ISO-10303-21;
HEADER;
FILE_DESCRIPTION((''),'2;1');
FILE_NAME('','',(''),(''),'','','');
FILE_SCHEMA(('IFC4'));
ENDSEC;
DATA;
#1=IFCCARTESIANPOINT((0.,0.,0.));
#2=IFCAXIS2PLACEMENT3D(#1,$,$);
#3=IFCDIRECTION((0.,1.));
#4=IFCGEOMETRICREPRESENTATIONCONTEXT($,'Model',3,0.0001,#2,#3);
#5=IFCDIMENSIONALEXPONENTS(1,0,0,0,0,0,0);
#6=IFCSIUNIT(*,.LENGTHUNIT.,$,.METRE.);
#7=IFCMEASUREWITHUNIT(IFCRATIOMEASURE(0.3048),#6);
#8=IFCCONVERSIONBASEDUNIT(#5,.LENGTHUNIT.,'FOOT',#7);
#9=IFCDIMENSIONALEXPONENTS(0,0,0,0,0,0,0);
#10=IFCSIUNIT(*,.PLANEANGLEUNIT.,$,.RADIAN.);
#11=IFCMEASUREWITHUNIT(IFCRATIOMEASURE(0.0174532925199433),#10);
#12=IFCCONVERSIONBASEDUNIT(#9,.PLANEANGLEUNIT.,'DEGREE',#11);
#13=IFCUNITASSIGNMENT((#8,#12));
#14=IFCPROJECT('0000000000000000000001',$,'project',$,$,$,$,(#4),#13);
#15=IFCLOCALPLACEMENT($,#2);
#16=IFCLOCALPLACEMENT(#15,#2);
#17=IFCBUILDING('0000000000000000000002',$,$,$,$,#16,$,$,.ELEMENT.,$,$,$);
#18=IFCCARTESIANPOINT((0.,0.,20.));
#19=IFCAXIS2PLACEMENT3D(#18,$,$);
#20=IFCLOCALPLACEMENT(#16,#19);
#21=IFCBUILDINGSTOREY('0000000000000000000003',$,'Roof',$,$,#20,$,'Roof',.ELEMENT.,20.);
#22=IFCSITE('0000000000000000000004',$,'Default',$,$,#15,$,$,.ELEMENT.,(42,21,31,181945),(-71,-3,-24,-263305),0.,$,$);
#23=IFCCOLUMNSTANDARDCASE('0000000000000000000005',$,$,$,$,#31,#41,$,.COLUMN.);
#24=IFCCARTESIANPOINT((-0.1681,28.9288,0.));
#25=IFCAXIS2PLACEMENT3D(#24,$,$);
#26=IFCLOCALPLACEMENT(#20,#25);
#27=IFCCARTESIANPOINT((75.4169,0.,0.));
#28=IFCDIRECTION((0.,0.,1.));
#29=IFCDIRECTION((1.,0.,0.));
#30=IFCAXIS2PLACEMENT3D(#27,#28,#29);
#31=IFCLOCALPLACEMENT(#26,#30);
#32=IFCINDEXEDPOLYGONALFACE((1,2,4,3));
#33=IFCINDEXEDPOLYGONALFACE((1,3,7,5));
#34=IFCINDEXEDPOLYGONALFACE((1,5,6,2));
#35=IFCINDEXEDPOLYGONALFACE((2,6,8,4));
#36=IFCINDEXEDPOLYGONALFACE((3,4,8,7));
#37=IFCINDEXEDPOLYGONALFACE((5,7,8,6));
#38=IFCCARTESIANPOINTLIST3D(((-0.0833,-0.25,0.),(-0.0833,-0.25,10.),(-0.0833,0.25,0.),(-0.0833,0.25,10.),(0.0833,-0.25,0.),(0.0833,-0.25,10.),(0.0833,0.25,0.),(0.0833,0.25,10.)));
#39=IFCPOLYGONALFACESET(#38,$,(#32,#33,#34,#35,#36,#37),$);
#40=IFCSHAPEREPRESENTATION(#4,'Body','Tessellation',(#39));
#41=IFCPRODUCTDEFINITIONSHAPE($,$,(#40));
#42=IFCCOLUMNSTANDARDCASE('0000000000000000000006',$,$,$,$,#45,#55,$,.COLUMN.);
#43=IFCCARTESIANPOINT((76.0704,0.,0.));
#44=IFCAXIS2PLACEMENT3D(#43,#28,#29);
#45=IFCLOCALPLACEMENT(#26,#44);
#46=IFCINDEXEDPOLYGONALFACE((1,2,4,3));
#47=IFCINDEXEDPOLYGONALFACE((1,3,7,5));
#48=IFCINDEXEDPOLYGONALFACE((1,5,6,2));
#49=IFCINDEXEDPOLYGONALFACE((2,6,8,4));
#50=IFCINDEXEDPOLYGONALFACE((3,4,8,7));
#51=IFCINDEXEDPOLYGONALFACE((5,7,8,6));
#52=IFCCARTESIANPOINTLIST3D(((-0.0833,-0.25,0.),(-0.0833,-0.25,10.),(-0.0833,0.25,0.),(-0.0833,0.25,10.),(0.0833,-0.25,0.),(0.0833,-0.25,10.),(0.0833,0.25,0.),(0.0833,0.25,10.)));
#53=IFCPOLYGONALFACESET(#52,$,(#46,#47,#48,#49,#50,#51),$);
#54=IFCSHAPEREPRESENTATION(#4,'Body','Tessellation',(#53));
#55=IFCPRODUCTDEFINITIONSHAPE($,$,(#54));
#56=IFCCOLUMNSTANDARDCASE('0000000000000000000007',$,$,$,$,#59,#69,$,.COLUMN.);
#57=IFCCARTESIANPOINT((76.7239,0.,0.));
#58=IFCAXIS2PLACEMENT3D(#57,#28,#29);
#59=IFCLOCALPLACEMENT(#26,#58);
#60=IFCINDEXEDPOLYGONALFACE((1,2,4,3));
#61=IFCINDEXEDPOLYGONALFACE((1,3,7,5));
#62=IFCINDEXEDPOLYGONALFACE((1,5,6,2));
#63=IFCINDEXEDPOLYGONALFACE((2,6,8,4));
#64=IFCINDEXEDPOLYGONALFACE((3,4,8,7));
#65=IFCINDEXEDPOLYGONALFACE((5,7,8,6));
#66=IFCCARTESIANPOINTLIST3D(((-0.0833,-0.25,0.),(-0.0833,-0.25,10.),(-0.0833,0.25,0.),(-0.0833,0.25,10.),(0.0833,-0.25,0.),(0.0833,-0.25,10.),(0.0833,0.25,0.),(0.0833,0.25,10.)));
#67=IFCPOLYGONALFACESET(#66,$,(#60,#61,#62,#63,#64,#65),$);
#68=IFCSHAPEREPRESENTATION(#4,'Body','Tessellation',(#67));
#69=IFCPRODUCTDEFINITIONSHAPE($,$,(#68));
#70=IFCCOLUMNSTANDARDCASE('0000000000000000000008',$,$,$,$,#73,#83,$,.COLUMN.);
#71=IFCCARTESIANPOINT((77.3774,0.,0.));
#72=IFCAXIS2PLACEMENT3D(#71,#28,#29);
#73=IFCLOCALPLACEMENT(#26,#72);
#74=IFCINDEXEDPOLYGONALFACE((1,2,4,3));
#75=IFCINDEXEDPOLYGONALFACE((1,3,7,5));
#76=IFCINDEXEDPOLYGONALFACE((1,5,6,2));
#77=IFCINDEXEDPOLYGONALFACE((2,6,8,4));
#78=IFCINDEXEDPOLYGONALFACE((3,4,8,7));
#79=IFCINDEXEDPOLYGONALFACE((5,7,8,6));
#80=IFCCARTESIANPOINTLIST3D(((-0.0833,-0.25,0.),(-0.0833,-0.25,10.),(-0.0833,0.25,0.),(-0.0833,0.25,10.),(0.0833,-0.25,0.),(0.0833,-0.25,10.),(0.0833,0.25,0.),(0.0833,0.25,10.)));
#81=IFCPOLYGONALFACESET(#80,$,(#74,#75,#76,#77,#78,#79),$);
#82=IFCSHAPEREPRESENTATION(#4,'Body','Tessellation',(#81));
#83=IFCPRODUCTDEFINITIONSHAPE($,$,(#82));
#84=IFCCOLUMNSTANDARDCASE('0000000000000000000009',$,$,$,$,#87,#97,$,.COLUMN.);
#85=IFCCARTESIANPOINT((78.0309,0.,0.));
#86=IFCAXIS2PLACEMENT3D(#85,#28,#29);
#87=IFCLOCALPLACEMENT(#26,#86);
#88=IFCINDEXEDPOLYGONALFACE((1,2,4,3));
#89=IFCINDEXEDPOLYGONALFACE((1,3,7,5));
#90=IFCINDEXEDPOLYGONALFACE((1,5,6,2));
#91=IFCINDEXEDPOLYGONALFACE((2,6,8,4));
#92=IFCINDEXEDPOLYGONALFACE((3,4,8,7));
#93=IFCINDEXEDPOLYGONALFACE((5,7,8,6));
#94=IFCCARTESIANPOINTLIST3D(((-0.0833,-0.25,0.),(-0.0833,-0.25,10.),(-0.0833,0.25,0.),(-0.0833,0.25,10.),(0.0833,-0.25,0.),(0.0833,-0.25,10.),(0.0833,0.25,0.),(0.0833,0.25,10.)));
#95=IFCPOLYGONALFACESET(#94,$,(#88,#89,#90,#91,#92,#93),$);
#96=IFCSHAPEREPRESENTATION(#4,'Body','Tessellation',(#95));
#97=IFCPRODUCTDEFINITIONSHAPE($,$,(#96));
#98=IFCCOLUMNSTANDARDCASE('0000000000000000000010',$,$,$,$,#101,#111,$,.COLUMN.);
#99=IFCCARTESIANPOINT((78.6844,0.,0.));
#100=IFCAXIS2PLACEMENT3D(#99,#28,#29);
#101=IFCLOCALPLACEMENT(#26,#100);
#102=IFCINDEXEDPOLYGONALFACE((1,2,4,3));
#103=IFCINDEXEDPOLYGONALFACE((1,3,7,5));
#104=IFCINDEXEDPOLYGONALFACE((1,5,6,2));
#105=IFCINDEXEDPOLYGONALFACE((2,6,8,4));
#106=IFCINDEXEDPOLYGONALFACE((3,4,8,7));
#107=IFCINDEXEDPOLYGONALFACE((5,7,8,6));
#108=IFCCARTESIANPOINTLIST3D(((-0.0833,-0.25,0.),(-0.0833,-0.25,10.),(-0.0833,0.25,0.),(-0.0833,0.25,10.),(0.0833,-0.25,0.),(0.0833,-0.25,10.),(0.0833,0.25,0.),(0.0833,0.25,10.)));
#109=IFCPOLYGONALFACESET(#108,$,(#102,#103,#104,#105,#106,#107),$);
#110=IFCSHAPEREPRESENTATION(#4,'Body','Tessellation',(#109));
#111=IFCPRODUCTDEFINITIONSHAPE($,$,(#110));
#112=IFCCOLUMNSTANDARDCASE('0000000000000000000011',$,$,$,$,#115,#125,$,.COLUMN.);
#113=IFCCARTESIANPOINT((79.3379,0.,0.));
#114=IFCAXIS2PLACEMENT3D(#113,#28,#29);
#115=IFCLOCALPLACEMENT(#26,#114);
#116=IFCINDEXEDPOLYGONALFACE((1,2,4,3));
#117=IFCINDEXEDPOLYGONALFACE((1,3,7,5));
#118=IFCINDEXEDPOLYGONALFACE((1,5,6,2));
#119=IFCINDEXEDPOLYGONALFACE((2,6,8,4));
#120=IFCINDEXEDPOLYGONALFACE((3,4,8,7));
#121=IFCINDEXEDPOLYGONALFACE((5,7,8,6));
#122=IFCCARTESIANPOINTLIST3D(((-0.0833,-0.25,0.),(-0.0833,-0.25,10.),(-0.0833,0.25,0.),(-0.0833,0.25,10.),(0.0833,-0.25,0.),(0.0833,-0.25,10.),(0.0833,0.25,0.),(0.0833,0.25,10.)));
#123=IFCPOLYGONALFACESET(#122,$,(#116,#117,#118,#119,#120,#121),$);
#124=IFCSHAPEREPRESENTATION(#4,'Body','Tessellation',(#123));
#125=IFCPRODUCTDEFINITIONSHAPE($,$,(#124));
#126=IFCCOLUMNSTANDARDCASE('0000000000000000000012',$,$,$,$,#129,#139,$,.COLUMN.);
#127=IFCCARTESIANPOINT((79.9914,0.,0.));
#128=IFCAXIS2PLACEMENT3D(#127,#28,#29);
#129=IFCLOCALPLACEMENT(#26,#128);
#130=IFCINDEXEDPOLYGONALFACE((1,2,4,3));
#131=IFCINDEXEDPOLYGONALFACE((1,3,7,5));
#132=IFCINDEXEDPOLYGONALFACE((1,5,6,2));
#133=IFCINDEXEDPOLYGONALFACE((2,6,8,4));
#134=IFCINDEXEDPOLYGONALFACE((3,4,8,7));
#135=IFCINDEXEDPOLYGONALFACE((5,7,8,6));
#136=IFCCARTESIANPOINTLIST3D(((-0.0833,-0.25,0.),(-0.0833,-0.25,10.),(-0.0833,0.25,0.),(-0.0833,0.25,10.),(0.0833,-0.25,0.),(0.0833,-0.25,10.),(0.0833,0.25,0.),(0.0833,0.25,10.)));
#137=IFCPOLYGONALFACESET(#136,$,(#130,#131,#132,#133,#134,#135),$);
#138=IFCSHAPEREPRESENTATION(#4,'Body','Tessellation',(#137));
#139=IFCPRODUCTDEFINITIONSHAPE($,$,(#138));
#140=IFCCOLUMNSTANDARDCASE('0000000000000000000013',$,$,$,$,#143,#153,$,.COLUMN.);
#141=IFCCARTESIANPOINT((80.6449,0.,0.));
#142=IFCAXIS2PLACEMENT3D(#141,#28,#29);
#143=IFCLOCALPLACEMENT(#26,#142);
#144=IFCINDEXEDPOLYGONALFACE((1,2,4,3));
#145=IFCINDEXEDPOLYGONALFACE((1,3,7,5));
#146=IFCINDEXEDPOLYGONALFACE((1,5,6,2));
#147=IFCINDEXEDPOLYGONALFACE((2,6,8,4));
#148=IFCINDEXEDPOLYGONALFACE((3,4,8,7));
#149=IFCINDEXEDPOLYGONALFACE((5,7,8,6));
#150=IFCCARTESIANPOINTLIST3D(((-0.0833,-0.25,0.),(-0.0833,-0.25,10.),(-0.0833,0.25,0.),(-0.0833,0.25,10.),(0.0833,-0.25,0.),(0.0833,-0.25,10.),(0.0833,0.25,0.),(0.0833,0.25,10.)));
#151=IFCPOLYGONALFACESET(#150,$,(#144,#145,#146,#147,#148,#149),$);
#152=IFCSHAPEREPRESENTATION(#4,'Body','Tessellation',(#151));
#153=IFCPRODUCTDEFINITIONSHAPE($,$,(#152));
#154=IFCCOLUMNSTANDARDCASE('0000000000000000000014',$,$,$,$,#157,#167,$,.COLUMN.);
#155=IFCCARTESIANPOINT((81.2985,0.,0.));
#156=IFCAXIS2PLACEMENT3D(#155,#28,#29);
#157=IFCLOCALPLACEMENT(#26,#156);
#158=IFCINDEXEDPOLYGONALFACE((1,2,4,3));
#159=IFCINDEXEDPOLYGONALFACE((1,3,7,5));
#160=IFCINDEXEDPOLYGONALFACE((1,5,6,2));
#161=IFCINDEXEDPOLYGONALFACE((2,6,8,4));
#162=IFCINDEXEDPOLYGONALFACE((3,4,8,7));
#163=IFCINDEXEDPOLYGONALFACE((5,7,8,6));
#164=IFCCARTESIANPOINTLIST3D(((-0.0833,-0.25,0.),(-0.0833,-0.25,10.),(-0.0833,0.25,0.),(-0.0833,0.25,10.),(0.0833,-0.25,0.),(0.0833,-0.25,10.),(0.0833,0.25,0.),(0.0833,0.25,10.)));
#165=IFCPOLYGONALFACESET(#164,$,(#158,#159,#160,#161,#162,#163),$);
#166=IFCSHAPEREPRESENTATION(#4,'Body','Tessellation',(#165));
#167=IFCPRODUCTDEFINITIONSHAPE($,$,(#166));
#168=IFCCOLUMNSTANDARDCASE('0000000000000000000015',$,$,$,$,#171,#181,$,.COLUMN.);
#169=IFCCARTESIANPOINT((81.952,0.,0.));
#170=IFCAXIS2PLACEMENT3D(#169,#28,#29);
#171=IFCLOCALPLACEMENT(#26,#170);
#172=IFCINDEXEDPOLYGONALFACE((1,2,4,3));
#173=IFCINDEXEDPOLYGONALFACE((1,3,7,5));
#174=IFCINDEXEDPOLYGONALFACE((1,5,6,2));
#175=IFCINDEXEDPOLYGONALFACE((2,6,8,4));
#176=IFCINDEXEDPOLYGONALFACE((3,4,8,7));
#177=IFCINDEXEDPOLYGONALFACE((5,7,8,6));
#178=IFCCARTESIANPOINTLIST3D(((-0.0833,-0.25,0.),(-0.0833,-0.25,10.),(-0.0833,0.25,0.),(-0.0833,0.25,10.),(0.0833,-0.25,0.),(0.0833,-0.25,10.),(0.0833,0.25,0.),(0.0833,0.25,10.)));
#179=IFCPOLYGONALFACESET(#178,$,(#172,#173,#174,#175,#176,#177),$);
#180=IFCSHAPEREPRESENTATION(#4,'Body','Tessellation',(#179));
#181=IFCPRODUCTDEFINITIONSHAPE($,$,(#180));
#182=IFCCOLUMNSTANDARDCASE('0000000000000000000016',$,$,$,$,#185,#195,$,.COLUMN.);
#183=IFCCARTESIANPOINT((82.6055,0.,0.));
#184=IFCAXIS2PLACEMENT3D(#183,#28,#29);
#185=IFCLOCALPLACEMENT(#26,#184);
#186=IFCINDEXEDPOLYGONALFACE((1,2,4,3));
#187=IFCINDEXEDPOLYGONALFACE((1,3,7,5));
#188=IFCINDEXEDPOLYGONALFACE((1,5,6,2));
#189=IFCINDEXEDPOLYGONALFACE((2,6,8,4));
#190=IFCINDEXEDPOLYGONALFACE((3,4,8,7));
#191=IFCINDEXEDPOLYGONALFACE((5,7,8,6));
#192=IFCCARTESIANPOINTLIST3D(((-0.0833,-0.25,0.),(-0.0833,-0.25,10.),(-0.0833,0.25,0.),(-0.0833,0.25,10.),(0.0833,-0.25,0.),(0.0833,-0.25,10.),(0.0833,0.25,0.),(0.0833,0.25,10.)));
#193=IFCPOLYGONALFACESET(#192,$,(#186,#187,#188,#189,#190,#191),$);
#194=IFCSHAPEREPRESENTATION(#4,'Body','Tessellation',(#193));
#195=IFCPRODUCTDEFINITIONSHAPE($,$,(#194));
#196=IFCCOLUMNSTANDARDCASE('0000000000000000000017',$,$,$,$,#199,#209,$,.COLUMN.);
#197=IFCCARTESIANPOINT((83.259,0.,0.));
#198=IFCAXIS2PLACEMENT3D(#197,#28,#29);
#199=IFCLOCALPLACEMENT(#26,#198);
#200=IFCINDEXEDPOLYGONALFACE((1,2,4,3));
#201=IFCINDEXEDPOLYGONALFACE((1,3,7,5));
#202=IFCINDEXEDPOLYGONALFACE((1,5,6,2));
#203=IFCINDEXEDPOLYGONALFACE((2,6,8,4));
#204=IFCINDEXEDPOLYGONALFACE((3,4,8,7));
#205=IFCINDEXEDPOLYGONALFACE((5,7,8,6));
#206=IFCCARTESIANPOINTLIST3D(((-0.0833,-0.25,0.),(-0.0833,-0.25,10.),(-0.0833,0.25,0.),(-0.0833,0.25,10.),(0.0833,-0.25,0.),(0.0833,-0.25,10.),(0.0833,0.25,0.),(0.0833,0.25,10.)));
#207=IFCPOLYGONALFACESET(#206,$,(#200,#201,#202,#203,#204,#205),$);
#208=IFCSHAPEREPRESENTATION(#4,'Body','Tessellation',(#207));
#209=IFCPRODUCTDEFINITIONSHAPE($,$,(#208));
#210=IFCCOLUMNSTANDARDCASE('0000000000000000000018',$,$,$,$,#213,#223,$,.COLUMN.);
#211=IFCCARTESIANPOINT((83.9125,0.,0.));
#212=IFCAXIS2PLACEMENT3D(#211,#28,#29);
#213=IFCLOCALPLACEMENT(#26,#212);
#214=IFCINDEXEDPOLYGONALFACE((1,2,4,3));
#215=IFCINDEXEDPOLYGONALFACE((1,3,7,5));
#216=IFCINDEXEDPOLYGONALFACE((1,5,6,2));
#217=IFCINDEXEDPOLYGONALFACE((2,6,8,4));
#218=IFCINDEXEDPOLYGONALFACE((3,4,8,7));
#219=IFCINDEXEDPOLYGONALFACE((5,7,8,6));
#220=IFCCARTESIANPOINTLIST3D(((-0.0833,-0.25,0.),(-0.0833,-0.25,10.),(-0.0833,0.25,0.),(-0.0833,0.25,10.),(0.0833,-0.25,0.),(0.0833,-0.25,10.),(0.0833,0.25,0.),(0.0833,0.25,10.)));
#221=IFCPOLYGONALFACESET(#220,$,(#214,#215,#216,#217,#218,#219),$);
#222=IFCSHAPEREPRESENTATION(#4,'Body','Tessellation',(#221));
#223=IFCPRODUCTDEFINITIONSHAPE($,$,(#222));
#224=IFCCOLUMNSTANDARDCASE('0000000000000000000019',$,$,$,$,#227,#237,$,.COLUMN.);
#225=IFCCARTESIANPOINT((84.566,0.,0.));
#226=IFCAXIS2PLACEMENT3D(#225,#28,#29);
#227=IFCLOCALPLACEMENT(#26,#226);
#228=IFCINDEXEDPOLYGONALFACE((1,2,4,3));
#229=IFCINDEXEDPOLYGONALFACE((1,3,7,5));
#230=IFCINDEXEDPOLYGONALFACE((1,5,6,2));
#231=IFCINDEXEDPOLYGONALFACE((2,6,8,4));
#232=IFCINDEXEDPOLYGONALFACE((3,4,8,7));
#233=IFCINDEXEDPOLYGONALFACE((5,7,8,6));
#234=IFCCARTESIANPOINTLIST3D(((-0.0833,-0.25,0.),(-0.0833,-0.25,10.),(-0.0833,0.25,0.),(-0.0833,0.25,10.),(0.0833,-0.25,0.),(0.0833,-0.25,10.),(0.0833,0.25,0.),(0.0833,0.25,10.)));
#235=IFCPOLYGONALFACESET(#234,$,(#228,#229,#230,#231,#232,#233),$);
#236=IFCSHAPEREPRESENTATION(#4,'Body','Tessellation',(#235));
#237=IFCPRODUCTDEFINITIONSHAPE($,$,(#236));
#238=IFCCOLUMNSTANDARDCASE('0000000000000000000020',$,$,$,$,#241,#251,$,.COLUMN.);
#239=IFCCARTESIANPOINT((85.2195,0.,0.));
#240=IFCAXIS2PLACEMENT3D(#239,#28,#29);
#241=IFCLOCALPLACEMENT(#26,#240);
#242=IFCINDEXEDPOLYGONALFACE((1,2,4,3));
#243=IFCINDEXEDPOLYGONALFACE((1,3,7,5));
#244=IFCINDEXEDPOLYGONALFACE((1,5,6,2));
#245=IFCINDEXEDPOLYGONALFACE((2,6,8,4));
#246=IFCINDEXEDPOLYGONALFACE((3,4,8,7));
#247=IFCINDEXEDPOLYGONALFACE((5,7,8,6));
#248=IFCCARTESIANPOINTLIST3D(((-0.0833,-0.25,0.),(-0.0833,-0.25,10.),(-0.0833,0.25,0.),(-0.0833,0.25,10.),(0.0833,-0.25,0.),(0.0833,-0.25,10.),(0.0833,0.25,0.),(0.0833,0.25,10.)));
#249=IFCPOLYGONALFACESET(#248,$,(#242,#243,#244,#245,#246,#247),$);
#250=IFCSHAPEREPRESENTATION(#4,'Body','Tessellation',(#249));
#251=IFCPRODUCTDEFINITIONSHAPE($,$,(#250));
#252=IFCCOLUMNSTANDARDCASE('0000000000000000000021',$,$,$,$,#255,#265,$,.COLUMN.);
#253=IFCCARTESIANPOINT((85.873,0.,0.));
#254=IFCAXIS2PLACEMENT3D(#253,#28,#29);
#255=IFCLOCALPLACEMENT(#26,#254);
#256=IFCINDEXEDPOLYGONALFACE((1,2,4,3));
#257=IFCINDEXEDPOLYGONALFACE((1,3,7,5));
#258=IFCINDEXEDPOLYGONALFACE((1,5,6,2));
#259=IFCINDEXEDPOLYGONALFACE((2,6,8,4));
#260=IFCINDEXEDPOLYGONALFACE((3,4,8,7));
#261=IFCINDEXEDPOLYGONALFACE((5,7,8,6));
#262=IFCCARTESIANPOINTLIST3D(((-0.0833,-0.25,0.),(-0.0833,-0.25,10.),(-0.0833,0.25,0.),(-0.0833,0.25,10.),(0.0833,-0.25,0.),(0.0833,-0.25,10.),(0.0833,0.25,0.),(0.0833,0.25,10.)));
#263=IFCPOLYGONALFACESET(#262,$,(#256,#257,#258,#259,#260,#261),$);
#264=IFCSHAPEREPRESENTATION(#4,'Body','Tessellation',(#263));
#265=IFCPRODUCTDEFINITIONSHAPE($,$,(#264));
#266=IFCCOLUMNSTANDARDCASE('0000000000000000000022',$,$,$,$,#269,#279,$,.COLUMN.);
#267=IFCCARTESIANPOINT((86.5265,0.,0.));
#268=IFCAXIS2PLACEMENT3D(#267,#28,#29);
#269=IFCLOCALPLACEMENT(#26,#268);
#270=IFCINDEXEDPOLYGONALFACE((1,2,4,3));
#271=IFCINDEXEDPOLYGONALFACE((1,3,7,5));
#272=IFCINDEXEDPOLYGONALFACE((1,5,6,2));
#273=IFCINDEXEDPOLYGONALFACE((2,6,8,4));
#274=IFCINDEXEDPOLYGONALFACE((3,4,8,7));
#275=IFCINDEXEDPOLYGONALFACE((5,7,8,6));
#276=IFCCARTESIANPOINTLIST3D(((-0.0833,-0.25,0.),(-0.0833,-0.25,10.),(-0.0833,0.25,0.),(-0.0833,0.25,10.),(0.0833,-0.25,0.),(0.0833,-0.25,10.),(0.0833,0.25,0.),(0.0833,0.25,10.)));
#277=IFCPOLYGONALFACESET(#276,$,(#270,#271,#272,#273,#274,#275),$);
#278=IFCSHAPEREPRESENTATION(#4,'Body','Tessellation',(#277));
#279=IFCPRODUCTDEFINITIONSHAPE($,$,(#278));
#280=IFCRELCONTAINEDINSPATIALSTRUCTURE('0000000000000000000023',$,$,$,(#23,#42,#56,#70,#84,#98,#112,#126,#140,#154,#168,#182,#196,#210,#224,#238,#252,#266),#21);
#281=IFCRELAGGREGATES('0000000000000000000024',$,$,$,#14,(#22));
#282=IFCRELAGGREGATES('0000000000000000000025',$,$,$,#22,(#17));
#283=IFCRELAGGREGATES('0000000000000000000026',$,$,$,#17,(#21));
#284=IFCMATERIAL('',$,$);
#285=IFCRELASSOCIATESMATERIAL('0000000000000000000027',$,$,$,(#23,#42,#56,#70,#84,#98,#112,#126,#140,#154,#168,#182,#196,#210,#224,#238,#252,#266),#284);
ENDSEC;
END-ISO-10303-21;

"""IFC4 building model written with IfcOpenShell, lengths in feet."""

from ifc_helpers import new_model, entity, si_unit, converted_unit, direction, frame, origin, place, context, project, spatial, rectangle, extrude, material, element, save


model = new_model("IFC4")

# Units and contexts
model_context = context("Model", 3, precision=0.0001, world=origin(), true_north=direction((0.0, 1.0)))
ifc_project = project(units=[converted_unit("LENGTHUNIT", "FOOT", entity("IfcRatioMeasure", 0.3048), si_unit("LENGTHUNIT", "METRE"), dimensions=[1, 0, 0, 0, 0, 0, 0]), converted_unit("PLANEANGLEUNIT", "DEGREE", entity("IfcRatioMeasure", 0.0174532925199433), si_unit("PLANEANGLEUNIT", "RADIAN"), dimensions=[0, 0, 0, 0, 0, 0, 0])], contexts=[model_context])

# Site, building, storey
site_placement = place(None, origin())
site = spatial("IfcSite", under=ifc_project, at=site_placement, Name="Default", CompositionType="ELEMENT", RefLatitude=(42, 21, 31, 181945), RefLongitude=(-71, -3, -24, -263305), RefElevation=0.0)
building_placement = place(site_placement, origin())
building = spatial("IfcBuilding", under=site, at=building_placement, CompositionType="ELEMENT")
storey_placement = place(building_placement, frame((0.0, 0.0, 20.0)))
storey = spatial("IfcBuildingStorey", under=building, at=storey_placement, Name="Roof", LongName="Roof", CompositionType="ELEMENT", Elevation=20.0)

# Columns
ifc_material_1 = material(Name="")
placement_1 = place(storey_placement, frame((-0.1681, 28.9288, 0.0)))
for number, where, z_axis, x_axis in (
    (1, (75.4169, 0.0, 0.0), (0.0, 0.0, 1.0), (1.0, 0.0, 0.0)),
    (2, (76.0704, 0.0, 0.0), (0.0, 0.0, 1.0), (1.0, 0.0, 0.0)),
    (3, (76.7239, 0.0, 0.0), (0.0, 0.0, 1.0), (1.0, 0.0, 0.0)),
    (4, (77.3774, 0.0, 0.0), (0.0, 0.0, 1.0), (1.0, 0.0, 0.0)),
    (5, (78.0309, 0.0, 0.0), (0.0, 0.0, 1.0), (1.0, 0.0, 0.0)),
    (6, (78.6844, 0.0, 0.0), (0.0, 0.0, 1.0), (1.0, 0.0, 0.0)),
    (7, (79.3379, 0.0, 0.0), (0.0, 0.0, 1.0), (1.0, 0.0, 0.0)),
    (8, (79.9914, 0.0, 0.0), (0.0, 0.0, 1.0), (1.0, 0.0, 0.0)),
    (9, (80.6449, 0.0, 0.0), (0.0, 0.0, 1.0), (1.0, 0.0, 0.0)),
    (10, (81.2985, 0.0, 0.0), (0.0, 0.0, 1.0), (1.0, 0.0, 0.0)),
    (11, (81.952, 0.0, 0.0), (0.0, 0.0, 1.0), (1.0, 0.0, 0.0)),
    (12, (82.6055, 0.0, 0.0), (0.0, 0.0, 1.0), (1.0, 0.0, 0.0)),
    (13, (83.259, 0.0, 0.0), (0.0, 0.0, 1.0), (1.0, 0.0, 0.0)),
    (14, (83.9125, 0.0, 0.0), (0.0, 0.0, 1.0), (1.0, 0.0, 0.0)),
    (15, (84.566, 0.0, 0.0), (0.0, 0.0, 1.0), (1.0, 0.0, 0.0)),
    (16, (85.2195, 0.0, 0.0), (0.0, 0.0, 1.0), (1.0, 0.0, 0.0)),
    (17, (85.873, 0.0, 0.0), (0.0, 0.0, 1.0), (1.0, 0.0, 0.0)),
    (18, (86.5265, 0.0, 0.0), (0.0, 0.0, 1.0), (1.0, 0.0, 0.0)),
):
    element("IfcColumnStandardCase", number, at=place(placement_1, frame(where, z_axis=z_axis, x_axis=x_axis)), inside=storey, material=ifc_material_1, PredefinedType="COLUMN", context=model_context, shape_type="SweptSolid", body=[
        extrude(rectangle(XDim=0.1667, YDim=0.5), origin(), (0.0, 0.0, 1.0), 10.0),
    ])

save(model, "model.ifc")
